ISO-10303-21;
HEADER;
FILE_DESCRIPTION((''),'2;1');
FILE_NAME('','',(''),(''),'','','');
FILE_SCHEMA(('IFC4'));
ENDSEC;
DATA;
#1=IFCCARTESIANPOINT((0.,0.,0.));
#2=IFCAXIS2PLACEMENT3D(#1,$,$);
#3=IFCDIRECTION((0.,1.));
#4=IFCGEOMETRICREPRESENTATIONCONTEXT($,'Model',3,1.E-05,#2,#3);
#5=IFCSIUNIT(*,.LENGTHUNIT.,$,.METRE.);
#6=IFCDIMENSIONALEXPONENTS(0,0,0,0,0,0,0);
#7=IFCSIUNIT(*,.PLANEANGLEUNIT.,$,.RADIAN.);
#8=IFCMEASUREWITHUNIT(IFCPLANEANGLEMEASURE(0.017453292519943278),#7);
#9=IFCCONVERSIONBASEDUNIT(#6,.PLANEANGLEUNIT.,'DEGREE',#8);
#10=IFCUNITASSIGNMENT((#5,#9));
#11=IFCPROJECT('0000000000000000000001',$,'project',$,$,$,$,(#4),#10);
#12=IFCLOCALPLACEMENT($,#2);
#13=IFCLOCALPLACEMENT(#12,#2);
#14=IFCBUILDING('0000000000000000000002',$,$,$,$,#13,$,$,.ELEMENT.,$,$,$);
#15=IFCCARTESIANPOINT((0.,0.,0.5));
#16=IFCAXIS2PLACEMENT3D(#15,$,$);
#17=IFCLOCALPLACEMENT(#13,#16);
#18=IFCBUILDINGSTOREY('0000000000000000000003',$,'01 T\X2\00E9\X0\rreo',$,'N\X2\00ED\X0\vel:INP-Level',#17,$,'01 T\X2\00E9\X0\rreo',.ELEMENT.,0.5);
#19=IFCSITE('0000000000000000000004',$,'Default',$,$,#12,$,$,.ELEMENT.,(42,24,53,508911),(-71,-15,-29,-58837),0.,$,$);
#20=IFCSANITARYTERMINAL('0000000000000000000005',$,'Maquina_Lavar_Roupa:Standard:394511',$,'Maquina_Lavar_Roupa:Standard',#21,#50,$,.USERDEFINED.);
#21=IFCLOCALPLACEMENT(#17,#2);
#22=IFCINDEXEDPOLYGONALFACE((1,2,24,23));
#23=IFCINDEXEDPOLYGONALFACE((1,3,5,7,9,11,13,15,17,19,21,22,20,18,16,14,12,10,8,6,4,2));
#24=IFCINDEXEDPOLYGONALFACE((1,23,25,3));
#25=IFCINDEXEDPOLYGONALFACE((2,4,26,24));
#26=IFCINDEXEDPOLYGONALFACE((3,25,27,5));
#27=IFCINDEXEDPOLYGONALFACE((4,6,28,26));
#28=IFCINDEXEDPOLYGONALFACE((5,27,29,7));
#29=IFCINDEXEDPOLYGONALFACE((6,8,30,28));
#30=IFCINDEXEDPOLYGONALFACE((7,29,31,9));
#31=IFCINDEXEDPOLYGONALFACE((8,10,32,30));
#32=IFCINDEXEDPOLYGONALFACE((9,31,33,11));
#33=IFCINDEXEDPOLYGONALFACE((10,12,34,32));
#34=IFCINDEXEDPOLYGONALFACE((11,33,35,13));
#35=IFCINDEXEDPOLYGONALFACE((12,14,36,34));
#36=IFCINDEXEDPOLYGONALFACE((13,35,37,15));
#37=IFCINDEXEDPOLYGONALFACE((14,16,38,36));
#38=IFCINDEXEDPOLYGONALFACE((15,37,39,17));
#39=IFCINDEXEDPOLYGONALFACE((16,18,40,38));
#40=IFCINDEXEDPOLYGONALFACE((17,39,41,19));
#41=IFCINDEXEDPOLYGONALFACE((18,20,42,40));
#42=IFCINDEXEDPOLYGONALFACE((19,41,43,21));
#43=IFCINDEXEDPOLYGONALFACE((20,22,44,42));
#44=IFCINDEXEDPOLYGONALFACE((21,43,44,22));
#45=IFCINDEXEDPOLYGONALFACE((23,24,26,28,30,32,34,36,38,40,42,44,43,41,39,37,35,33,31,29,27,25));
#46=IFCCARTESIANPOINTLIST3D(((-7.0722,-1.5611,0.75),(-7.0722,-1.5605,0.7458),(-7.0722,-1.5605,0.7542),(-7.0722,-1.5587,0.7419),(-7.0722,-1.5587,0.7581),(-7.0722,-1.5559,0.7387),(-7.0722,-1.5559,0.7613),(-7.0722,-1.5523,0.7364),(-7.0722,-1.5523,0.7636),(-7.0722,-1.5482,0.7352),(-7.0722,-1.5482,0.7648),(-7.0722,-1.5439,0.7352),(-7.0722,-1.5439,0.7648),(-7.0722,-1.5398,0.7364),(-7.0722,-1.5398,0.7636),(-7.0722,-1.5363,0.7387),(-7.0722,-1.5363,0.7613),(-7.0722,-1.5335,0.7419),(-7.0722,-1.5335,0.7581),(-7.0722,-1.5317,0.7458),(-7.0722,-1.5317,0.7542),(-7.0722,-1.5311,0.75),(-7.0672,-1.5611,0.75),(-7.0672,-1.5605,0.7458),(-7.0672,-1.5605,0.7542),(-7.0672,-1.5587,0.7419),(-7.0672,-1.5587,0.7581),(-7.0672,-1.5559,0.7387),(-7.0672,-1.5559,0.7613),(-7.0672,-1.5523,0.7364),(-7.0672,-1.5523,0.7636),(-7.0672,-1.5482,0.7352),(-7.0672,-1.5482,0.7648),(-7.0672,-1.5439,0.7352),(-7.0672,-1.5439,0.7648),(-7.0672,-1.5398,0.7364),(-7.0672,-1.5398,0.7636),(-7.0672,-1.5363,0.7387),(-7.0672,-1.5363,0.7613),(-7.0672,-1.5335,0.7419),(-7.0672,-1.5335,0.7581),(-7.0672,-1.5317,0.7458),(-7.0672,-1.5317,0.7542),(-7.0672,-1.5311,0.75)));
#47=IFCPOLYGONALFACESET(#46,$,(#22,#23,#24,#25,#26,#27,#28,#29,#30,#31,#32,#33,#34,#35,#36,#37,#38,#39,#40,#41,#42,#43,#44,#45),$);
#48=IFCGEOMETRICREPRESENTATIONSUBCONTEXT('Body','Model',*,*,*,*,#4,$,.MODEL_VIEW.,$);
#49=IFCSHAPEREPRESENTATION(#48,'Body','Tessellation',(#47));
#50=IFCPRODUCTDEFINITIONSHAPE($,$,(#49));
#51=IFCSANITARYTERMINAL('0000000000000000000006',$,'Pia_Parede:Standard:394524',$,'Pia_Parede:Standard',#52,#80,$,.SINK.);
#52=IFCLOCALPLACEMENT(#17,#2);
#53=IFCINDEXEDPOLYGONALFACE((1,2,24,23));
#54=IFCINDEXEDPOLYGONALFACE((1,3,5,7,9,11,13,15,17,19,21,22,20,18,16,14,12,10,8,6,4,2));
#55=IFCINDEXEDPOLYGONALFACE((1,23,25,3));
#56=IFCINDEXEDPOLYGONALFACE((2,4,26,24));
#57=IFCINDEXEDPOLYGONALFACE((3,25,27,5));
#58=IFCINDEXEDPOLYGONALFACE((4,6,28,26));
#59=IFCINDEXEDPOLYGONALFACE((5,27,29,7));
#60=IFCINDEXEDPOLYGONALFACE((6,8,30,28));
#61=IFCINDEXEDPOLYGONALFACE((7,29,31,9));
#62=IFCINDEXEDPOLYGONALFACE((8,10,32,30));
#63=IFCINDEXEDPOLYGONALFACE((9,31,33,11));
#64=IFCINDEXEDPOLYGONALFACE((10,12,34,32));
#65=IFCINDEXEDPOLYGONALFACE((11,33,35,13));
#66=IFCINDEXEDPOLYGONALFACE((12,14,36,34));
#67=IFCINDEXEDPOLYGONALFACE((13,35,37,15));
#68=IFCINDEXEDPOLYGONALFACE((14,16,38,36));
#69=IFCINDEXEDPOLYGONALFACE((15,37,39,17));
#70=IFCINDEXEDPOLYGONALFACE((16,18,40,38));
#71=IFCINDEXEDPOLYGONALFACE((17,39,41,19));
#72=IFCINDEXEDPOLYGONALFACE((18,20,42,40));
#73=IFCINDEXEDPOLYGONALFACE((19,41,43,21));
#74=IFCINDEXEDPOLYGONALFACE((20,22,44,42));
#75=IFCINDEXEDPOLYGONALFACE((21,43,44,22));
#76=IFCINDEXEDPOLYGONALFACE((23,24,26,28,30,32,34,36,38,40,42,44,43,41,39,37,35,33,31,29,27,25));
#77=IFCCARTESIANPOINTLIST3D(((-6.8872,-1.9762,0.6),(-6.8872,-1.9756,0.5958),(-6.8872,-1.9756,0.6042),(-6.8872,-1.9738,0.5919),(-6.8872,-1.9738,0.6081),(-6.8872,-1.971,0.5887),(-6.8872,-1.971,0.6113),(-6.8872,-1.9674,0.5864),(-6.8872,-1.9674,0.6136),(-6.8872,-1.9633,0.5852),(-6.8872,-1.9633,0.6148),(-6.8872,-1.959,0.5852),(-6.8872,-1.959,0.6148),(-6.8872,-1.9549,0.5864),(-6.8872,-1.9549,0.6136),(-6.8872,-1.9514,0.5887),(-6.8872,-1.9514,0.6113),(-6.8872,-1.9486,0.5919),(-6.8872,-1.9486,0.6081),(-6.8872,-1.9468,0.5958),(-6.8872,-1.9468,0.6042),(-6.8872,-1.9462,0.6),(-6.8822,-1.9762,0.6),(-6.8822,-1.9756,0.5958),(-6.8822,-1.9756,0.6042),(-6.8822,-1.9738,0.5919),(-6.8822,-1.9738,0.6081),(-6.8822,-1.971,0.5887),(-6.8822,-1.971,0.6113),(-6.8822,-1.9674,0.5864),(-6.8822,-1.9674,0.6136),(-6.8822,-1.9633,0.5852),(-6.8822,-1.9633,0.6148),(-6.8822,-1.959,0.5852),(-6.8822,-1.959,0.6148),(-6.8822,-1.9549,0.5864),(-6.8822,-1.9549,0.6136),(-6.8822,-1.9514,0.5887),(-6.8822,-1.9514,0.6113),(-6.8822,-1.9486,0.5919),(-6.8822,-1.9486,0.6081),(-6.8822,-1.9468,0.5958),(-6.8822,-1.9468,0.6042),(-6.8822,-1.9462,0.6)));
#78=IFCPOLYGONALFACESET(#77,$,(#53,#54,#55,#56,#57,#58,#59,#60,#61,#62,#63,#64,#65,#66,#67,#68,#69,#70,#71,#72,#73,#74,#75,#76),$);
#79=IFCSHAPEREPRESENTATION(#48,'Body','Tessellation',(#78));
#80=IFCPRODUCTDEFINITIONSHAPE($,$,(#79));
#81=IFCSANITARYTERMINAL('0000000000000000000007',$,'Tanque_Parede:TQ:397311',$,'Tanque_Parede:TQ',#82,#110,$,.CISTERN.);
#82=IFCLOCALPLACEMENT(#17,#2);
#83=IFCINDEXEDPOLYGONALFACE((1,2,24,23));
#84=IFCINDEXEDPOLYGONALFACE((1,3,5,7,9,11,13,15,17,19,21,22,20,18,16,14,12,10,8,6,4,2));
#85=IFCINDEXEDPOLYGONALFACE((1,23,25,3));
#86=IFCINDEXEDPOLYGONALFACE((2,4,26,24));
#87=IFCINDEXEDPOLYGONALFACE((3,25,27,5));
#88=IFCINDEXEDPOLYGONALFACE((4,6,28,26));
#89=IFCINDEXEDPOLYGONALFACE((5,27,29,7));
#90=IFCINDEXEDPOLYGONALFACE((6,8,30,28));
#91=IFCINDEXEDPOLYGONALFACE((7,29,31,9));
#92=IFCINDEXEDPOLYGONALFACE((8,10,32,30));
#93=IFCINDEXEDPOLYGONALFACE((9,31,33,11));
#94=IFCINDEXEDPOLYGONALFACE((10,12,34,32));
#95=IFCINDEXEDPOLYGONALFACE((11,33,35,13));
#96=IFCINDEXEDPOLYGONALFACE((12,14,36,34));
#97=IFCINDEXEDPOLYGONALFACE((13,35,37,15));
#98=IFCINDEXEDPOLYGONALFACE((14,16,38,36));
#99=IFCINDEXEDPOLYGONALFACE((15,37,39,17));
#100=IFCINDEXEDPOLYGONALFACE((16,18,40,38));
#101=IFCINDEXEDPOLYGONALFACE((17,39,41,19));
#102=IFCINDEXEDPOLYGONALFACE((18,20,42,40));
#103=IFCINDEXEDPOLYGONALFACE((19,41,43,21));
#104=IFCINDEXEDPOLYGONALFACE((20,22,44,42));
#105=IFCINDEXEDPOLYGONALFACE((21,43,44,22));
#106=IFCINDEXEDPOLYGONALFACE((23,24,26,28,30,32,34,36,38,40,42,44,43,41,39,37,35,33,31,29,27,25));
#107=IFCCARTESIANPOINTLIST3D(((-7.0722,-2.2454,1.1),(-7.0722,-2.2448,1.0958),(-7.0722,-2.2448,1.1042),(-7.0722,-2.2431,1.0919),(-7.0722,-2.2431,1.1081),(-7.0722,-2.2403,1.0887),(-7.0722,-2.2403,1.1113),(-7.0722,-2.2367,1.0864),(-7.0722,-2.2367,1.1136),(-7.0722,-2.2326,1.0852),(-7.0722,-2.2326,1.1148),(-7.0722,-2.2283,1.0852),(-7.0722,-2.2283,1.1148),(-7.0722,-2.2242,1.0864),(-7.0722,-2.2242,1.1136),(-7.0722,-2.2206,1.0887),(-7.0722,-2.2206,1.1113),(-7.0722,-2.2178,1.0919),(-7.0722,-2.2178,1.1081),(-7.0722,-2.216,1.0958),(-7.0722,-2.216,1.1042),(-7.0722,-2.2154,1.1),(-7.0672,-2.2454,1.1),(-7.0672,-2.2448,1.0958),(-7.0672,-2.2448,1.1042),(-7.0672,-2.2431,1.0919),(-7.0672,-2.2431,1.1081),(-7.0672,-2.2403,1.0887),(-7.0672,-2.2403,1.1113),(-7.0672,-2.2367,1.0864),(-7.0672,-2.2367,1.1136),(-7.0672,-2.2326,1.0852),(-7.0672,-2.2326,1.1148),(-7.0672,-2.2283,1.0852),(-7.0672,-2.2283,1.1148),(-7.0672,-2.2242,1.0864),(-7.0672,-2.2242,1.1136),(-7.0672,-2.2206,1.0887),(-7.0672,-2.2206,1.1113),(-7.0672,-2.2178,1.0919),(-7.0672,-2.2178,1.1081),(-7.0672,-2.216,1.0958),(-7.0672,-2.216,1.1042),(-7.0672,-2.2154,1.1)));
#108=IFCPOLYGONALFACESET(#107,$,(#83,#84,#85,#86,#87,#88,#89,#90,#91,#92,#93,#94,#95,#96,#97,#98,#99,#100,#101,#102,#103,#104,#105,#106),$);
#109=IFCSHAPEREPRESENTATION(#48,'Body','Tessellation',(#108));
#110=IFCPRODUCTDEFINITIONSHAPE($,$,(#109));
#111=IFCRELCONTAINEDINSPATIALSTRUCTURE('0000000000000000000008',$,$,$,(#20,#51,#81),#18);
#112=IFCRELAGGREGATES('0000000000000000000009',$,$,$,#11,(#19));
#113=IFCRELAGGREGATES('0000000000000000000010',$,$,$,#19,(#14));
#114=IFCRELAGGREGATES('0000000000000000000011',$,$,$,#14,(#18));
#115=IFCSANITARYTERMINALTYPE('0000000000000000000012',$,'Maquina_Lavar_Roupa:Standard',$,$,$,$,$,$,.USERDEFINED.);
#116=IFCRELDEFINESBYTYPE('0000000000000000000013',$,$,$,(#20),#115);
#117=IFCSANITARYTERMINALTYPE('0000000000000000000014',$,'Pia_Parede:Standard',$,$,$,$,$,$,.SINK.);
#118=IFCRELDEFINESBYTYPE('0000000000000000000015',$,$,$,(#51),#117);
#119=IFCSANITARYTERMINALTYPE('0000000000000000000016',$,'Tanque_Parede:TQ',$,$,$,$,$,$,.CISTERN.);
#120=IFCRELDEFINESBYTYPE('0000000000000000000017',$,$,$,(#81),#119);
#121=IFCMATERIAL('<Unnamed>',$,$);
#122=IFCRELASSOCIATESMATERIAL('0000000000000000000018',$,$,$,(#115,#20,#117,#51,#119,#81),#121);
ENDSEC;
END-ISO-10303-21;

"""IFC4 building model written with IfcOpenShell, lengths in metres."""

from ifc_helpers import new_model, entity, si_unit, converted_unit, direction, frame, origin, place, context, subcontext, project, spatial, arc, indexed_curve, outline, extrude, source, transform, mapped, material, type_object, type_shapes, element, save


model = new_model("IFC4")

# Units and contexts
model_context = context("Model", 3, precision=1e-05, world=origin(), true_north=direction((0.0, 1.0)))
body_context = subcontext(model_context, "Body", "Model", "MODEL_VIEW")
ifc_project = project(units=[si_unit("LENGTHUNIT", "METRE"), converted_unit("PLANEANGLEUNIT", "DEGREE", entity("IfcPlaneAngleMeasure", 0.017453292519943278), si_unit("PLANEANGLEUNIT", "RADIAN"), dimensions=[0, 0, 0, 0, 0, 0, 0])], contexts=[model_context])

# Site, building, storey
site_placement = place(None, origin())
site = spatial("IfcSite", under=ifc_project, at=site_placement, Name="Default", CompositionType="ELEMENT", RefLatitude=(42, 24, 53, 508911), RefLongitude=(-71, -15, -29, -58837), RefElevation=0.0)
building_placement = place(site_placement, origin())
building = spatial("IfcBuilding", under=site, at=building_placement, CompositionType="ELEMENT")
storey_placement = place(building_placement, frame((0.0, 0.0, 0.5)))
storey = spatial("IfcBuildingStorey", under=building, at=storey_placement, Name="01 Térreo", ObjectType="Nível:INP-Level", LongName="01 Térreo", CompositionType="ELEMENT", Elevation=0.5)

# Sanitary terminals
ifc_material = material(Name="<Unnamed>")
sanitary_terminal_type_1 = type_object("IfcSanitaryTerminalType", Name="Maquina_Lavar_Roupa:Standard", PredefinedType="USERDEFINED", material=ifc_material)
shared_shape_1 = source(origin(), body_context, "Body", "SweptSolid", [
    extrude(outline(indexed_curve([(-0.015, 0.0), (0.0, -0.015), (0.015, 0.0), (0.0, 0.015)], segments=[arc(1, 2, 3), arc(3, 4, 1)], self_intersect=False)), frame((-0.37, -0.005, 0.75), z_axis=(0.0, 1.0, 0.0), x_axis=(1.0, 0.0, 0.0)), (0.0, 0.0, 1.0), 0.005),
])
type_shapes(sanitary_terminal_type_1, [shared_shape_1])
sanitary_terminal_1_placement = place(storey_placement, frame((-7.0722, -1.1761, 0.0), z_axis=(0.0, 0.0, 1.0), x_axis=(0.0, 1.0, 0.0)))
element("IfcSanitaryTerminal", 1, at=sanitary_terminal_1_placement, inside=storey, type_object=sanitary_terminal_type_1, material=ifc_material, Name="Maquina_Lavar_Roupa:Standard:394511", ObjectType="Maquina_Lavar_Roupa:Standard", PredefinedType="USERDEFINED", context=body_context, shape_type="MappedRepresentation", body=[
    mapped(shared_shape_1, transform((0.0, 0.0, 0.0), scale=1.0)),
])
sanitary_terminal_type_2 = type_object("IfcSanitaryTerminalType", Name="Pia_Parede:Standard", PredefinedType="SINK", material=ifc_material)
shared_shape_2 = source(origin(), body_context, "Body", "SweptSolid", [
    extrude(outline(indexed_curve([(-0.015, 0.0), (0.0, -0.015), (0.015, 0.0), (0.0, 0.015)], segments=[arc(1, 2, 3), arc(3, 4, 1)], self_intersect=False)), frame((-0.1, -0.005, 0.6), z_axis=(0.0, 1.0, 0.0), x_axis=(1.0, 0.0, 0.0)), (0.0, 0.0, 1.0), 0.005),
])
type_shapes(sanitary_terminal_type_2, [shared_shape_2])
sanitary_terminal_2_placement = place(storey_placement, frame((-6.8822, -2.0612, 0.0), z_axis=(0.0, 0.0, 1.0), x_axis=(0.0, -1.0, 0.0)))
element("IfcSanitaryTerminal", 2, at=sanitary_terminal_2_placement, inside=storey, type_object=sanitary_terminal_type_2, material=ifc_material, Name="Pia_Parede:Standard:394524", ObjectType="Pia_Parede:Standard", PredefinedType="SINK", context=body_context, shape_type="MappedRepresentation", body=[
    mapped(shared_shape_2, transform((0.0, 0.0, 0.0), scale=1.0)),
])
sanitary_terminal_type_3 = type_object("IfcSanitaryTerminalType", Name="Tanque_Parede:TQ", PredefinedType="CISTERN", material=ifc_material)
shared_shape_3 = source(origin(), body_context, "Body", "SweptSolid", [
    extrude(outline(indexed_curve([(-0.015, 0.0), (0.0, -0.015), (0.015, 0.0), (0.0, 0.015)], segments=[arc(1, 2, 3), arc(3, 4, 1)], self_intersect=False)), frame((0.0, -0.005, 1.1), z_axis=(0.0, 1.0, 0.0), x_axis=(1.0, 0.0, 0.0)), (0.0, 0.0, 1.0), 0.005),
])
type_shapes(sanitary_terminal_type_3, [shared_shape_3])
sanitary_terminal_3_placement = place(storey_placement, frame((-7.0722, -2.2304, 0.0), z_axis=(0.0, 0.0, 1.0), x_axis=(0.0, 1.0, 0.0)))
element("IfcSanitaryTerminal", 3, at=sanitary_terminal_3_placement, inside=storey, type_object=sanitary_terminal_type_3, material=ifc_material, Name="Tanque_Parede:TQ:397311", ObjectType="Tanque_Parede:TQ", PredefinedType="CISTERN", context=body_context, shape_type="MappedRepresentation", body=[
    mapped(shared_shape_3, transform((0.0, 0.0, 0.0), scale=1.0)),
])

save(model, "model.ifc")
